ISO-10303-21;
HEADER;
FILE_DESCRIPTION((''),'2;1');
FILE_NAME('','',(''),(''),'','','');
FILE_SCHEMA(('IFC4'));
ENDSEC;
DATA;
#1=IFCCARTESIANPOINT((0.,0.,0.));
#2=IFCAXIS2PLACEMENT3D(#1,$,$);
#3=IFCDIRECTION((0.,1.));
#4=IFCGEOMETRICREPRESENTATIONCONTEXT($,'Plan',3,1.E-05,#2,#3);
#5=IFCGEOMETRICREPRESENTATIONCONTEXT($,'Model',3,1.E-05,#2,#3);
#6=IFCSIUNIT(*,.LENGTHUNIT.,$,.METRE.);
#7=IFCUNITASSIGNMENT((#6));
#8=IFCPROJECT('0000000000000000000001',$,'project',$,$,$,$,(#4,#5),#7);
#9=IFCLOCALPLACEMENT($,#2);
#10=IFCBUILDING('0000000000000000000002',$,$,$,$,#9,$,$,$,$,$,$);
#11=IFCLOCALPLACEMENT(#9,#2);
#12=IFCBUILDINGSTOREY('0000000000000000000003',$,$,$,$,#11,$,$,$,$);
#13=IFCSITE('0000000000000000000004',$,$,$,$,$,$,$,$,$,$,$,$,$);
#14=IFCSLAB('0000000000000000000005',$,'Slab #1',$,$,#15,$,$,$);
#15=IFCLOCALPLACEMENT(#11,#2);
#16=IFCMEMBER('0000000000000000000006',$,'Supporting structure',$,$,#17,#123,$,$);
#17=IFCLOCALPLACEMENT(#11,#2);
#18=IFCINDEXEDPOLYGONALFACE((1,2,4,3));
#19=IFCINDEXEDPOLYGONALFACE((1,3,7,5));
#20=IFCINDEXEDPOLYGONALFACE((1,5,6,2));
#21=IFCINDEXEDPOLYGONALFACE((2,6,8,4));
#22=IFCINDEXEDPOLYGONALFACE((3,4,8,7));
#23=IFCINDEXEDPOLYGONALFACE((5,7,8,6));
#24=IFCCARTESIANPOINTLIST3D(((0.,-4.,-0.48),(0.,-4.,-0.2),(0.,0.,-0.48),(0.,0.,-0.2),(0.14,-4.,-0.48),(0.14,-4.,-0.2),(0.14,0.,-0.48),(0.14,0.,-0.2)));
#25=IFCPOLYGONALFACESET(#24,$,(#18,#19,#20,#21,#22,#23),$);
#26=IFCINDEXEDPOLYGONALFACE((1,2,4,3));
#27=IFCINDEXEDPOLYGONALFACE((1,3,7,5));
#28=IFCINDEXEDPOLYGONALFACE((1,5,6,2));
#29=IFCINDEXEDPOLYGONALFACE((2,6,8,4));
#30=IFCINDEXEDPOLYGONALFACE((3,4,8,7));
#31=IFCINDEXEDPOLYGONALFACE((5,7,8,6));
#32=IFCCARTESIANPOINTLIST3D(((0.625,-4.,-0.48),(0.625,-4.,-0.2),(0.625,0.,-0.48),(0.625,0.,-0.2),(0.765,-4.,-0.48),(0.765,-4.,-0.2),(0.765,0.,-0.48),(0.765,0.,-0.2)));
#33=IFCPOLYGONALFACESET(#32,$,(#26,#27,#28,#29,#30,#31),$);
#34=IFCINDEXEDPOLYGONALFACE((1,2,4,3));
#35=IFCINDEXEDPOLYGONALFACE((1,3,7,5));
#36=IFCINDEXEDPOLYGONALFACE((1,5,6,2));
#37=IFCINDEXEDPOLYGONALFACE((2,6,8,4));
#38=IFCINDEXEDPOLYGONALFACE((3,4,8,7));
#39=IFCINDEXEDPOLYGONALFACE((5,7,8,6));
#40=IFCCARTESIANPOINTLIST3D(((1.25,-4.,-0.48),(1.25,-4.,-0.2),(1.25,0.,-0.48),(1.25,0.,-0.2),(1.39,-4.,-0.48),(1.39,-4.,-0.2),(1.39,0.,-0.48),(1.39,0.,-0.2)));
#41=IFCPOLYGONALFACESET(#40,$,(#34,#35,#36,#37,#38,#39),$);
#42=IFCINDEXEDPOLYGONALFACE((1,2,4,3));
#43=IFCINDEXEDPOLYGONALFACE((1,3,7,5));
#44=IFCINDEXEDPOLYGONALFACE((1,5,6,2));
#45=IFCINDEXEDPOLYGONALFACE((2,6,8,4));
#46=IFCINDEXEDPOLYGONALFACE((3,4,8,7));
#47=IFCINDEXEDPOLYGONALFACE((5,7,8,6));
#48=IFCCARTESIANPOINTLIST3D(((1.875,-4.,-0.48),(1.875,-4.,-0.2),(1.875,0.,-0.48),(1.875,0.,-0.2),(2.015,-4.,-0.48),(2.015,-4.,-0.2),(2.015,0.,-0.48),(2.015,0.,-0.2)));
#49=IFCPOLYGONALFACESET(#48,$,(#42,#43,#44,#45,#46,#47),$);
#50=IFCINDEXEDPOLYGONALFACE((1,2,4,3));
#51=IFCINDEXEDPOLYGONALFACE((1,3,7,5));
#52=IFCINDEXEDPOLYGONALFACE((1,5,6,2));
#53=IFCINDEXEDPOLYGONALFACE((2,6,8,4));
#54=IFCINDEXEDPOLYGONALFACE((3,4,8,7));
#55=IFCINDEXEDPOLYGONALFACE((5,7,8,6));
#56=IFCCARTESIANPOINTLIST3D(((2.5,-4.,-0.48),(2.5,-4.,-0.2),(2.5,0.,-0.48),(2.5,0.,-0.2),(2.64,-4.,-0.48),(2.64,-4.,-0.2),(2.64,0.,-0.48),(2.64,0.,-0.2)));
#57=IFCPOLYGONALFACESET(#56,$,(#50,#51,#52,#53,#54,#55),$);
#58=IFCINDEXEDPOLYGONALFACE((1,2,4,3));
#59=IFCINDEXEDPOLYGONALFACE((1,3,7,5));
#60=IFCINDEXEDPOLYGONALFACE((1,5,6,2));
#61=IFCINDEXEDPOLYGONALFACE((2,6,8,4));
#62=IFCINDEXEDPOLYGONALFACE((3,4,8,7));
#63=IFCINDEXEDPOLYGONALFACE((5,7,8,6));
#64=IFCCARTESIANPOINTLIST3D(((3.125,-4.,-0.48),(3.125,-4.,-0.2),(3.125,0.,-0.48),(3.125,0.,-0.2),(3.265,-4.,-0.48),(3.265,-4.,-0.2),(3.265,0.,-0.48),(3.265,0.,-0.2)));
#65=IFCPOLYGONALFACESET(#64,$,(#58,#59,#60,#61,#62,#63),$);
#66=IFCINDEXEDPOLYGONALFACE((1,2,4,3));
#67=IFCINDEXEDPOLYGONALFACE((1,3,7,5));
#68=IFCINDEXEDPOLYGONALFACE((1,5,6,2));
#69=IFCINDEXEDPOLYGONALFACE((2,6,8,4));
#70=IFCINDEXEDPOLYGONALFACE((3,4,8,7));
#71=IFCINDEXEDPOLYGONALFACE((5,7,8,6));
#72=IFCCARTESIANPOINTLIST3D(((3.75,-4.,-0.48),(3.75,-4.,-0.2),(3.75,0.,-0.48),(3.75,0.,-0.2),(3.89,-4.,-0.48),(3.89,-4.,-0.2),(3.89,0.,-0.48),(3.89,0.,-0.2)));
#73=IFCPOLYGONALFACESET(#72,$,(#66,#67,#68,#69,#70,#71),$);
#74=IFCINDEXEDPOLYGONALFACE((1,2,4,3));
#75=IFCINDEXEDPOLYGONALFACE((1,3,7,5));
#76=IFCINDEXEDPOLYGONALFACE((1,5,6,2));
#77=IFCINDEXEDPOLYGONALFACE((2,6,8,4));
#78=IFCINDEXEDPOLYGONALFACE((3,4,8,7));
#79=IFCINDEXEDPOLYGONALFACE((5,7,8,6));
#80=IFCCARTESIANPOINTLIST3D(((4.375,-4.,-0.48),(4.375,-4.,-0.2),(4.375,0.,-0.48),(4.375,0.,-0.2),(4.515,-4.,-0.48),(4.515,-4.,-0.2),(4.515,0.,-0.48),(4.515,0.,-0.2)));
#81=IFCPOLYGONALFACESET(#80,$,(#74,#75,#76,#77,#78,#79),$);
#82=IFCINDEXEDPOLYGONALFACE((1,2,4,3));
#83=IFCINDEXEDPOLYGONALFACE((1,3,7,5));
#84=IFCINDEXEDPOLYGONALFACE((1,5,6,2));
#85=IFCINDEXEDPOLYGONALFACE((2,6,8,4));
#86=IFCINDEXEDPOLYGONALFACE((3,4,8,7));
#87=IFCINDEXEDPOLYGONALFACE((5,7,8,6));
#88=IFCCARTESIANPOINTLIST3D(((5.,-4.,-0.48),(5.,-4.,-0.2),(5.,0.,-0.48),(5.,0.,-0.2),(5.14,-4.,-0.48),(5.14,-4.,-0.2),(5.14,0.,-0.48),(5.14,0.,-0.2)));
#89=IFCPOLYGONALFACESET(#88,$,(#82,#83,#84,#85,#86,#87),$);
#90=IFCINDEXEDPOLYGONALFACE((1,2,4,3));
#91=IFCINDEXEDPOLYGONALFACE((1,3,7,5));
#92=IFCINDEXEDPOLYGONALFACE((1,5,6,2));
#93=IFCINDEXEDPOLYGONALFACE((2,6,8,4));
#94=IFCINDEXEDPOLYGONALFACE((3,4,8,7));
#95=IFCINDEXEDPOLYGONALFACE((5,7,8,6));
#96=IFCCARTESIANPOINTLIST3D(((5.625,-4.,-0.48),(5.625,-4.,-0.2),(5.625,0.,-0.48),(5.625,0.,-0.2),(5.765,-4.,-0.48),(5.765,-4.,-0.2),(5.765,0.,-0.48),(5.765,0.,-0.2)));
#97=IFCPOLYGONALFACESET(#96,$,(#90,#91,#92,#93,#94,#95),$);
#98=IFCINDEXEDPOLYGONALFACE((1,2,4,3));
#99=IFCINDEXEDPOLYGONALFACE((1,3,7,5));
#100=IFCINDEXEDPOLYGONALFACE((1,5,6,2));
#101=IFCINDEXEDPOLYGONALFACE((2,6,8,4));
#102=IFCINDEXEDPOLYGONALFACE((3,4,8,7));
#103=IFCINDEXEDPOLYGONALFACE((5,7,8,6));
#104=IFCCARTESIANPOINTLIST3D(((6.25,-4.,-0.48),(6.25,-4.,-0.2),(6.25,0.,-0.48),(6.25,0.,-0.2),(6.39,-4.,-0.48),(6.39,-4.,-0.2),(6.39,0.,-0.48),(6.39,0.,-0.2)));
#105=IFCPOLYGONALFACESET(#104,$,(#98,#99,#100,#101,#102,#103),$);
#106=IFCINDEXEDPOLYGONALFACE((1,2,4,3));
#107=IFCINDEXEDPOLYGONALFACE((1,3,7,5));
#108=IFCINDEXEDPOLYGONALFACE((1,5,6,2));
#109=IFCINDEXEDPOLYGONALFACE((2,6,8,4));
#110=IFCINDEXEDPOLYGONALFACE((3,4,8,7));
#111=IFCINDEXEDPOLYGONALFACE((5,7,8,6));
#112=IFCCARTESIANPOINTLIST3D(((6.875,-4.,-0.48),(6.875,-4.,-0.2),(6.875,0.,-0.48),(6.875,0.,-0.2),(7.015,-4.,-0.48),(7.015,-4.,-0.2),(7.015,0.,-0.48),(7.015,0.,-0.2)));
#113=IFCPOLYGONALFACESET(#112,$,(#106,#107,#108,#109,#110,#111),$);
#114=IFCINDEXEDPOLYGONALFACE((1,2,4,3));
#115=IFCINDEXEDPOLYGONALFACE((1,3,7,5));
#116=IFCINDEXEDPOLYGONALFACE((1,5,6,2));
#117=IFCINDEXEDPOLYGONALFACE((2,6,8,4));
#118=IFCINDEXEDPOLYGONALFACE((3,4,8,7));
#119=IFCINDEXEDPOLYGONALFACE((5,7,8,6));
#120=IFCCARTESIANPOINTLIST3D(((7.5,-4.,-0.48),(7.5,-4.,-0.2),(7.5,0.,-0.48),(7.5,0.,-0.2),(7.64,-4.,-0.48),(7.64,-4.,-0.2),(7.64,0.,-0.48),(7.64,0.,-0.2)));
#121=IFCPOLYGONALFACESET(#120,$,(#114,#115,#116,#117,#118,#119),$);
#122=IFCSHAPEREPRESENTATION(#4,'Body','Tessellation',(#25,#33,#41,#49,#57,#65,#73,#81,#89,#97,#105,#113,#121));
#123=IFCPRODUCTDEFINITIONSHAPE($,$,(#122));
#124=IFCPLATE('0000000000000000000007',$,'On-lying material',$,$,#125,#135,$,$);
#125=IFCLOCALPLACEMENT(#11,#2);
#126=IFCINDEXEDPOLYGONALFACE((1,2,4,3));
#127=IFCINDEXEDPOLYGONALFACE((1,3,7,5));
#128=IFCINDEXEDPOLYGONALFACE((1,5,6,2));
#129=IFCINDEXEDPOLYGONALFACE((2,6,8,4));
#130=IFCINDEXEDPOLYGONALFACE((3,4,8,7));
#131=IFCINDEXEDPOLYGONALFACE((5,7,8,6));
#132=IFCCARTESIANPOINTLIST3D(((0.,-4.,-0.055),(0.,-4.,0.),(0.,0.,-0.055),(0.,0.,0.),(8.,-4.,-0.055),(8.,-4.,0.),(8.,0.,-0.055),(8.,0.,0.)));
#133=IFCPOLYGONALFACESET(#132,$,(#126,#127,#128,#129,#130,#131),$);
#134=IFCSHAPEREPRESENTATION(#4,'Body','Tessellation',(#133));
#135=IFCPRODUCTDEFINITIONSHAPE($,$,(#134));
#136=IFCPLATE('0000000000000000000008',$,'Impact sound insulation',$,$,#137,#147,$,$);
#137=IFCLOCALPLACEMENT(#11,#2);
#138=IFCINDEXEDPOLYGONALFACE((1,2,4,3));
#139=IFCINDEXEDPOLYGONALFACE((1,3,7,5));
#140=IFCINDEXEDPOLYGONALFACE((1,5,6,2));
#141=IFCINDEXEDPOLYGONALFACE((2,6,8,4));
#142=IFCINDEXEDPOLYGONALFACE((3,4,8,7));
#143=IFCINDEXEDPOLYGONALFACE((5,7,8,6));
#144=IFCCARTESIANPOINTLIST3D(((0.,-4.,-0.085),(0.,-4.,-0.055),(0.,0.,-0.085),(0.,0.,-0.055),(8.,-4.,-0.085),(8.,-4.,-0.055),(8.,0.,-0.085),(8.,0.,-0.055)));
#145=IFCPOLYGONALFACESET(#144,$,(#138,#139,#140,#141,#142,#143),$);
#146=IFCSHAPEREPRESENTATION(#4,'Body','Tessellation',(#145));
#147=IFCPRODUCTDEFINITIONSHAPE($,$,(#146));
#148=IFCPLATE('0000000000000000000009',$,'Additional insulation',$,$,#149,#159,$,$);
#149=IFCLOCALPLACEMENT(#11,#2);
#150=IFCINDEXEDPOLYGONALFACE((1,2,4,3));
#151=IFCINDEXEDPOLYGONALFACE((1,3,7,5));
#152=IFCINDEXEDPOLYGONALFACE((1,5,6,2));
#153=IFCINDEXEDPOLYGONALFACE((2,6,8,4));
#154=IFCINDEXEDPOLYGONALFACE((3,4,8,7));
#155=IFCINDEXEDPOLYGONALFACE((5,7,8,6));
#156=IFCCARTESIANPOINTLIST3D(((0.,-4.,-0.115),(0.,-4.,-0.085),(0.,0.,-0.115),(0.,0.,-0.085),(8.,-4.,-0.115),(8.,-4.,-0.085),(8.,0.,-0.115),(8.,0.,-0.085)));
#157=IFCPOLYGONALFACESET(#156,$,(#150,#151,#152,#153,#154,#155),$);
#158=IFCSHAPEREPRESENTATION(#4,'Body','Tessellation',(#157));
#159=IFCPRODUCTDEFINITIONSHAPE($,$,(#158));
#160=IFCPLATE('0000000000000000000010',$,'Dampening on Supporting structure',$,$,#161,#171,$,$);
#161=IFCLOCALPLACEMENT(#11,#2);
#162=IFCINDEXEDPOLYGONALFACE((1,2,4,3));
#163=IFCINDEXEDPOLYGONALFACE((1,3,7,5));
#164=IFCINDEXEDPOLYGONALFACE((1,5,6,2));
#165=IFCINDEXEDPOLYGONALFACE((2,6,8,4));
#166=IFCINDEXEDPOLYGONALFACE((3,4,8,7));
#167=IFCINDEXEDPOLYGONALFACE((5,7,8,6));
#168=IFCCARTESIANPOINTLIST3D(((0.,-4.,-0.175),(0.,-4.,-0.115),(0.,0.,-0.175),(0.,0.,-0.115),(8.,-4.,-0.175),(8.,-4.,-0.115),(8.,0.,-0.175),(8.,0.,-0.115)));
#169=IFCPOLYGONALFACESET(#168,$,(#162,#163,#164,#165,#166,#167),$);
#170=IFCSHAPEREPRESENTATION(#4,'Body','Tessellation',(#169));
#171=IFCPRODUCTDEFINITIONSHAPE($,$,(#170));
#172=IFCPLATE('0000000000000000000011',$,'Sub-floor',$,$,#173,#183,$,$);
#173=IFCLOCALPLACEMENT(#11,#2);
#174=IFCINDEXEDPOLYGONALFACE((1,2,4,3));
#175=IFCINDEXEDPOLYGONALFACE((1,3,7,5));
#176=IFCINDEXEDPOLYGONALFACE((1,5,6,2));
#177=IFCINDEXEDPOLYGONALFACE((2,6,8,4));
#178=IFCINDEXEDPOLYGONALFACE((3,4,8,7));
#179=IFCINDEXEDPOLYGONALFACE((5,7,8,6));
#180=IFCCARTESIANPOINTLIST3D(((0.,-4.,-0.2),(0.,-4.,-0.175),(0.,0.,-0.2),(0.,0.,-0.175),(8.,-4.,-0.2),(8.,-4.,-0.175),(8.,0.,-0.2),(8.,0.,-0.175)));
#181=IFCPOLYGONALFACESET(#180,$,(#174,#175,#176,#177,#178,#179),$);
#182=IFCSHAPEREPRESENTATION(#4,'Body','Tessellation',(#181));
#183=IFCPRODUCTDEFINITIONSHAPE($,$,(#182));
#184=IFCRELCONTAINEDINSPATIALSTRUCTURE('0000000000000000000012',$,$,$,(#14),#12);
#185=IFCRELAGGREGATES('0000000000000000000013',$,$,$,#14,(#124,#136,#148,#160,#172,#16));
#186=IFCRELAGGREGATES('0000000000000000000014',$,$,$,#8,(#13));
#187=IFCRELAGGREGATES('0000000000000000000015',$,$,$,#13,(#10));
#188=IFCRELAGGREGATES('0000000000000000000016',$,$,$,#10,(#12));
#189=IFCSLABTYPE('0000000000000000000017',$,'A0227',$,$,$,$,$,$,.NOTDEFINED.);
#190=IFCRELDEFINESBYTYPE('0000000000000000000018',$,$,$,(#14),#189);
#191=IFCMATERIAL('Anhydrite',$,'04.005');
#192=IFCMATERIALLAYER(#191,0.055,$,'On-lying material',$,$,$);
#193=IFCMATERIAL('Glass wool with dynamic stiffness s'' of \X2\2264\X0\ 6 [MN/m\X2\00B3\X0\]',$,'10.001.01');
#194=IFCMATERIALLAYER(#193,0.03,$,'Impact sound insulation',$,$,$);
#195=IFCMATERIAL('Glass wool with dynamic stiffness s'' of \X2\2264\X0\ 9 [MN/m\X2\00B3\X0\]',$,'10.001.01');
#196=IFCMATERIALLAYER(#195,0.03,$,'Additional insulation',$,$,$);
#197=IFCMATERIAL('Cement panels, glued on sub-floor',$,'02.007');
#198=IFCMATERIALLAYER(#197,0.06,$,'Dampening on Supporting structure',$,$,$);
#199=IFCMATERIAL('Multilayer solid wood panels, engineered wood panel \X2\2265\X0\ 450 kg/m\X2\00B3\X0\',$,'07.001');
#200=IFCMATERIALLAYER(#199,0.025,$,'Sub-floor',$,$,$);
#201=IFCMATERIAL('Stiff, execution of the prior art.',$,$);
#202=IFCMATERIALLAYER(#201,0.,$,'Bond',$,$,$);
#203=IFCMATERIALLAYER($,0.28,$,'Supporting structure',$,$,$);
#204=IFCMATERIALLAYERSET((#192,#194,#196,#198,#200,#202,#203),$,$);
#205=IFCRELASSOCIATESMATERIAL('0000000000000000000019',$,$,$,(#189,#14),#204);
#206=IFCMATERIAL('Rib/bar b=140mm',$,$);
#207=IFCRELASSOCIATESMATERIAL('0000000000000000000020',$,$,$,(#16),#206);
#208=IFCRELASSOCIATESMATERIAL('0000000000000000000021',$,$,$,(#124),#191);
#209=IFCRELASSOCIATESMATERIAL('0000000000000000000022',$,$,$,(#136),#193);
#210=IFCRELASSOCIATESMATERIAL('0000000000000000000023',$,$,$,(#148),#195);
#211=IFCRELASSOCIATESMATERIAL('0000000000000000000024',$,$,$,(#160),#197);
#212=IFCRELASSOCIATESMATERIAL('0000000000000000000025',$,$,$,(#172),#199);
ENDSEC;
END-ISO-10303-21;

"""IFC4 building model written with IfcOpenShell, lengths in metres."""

from ifc_helpers import new_model, si_unit, direction, frame, frame_2d, origin, origin_with_axes, place, context, project, spatial, rectangle, extrude, material, layer, layer_set, type_object, element, aggregate, save


model = new_model("IFC4")

# Units and contexts
plan_context = context("Plan", 3, precision=1e-05, world=origin(), true_north=direction((0.0, 1.0)))
model_context = context("Model", 3, precision=1e-05, world=origin(), true_north=direction((0.0, 1.0)))
ifc_project = project(units=[si_unit("LENGTHUNIT", "METRE")], contexts=[plan_context, model_context])

# Site, building, storey
site = spatial("IfcSite", under=ifc_project)
building_placement = place(None, origin())
building = spatial("IfcBuilding", under=site, at=building_placement)
storey_placement = place(building_placement, origin())
storey = spatial("IfcBuildingStorey", under=building, at=storey_placement)

# Slab, member, plates
ifc_material_1 = material(Name="Anhydrite", Category="04.005")
ifc_layer_1 = layer(ifc_material_1, 0.055, Name="On-lying material")
ifc_material_2 = material(Name="Glass wool with dynamic stiffness s' of ≤ 6 [MN/m³]", Category="10.001.01")
ifc_layer_2 = layer(ifc_material_2, 0.03, Name="Impact sound insulation")
ifc_material_3 = material(Name="Glass wool with dynamic stiffness s' of ≤ 9 [MN/m³]", Category="10.001.01")
ifc_layer_3 = layer(ifc_material_3, 0.03, Name="Additional insulation")
ifc_material_4 = material(Name="Cement panels, glued on sub-floor", Category="02.007")
ifc_layer_4 = layer(ifc_material_4, 0.06, Name="Dampening on Supporting structure")
ifc_material_5 = material(Name="Multilayer solid wood panels, engineered wood panel ≥ 450 kg/m³", Category="07.001")
ifc_layer_5 = layer(ifc_material_5, 0.025, Name="Sub-floor")
ifc_material_6 = material(Name="Stiff, execution of the prior art.")
ifc_layer_6 = layer(ifc_material_6, 0.0, Name="Bond")
ifc_layer_7 = layer(None, 0.28, Name="Supporting structure")
ifc_layer_set = layer_set([ifc_layer_1, ifc_layer_2, ifc_layer_3, ifc_layer_4, ifc_layer_5, ifc_layer_6, ifc_layer_7])
slab_type = type_object("IfcSlabType", Name="A0227", PredefinedType="NOTDEFINED", material=ifc_layer_set)
slab_placement = place(None, frame((0.0, 0.0, 0.0), z_axis=(0.0, 0.0, -1.0), x_axis=(1.0, 0.0, 0.0)))
slab = element("IfcSlab", 1, at=slab_placement, inside=storey, type_object=slab_type, material=ifc_layer_set, Name="Slab #1")
ifc_material_7 = material(Name="Rib/bar b=140mm")
member_placement = place(slab_placement, origin())
member = element("IfcMember", 2, at=member_placement, material=ifc_material_7, Name="Supporting structure", context=plan_context, shape_type="SweptSolid", body=[
    extrude(rectangle(XDim=0.14, YDim=0.28, at=frame_2d((0.07, 0.14), x_axis=(1.0, 0.0))), frame((0.0, 4.0, 0.2), z_axis=(0.0, -1.0, 0.0), x_axis=(1.0, 0.0, 0.0)), (0.0, 0.0, 1.0), 4.0),
    extrude(rectangle(XDim=0.14, YDim=0.28, at=frame_2d((0.07, 0.14), x_axis=(1.0, 0.0))), frame((0.625, 4.0, 0.2), z_axis=(0.0, -1.0, 0.0), x_axis=(1.0, 0.0, 0.0)), (0.0, 0.0, 1.0), 4.0),
    extrude(rectangle(XDim=0.14, YDim=0.28, at=frame_2d((0.07, 0.14), x_axis=(1.0, 0.0))), frame((1.25, 4.0, 0.2), z_axis=(0.0, -1.0, 0.0), x_axis=(1.0, 0.0, 0.0)), (0.0, 0.0, 1.0), 4.0),
    extrude(rectangle(XDim=0.14, YDim=0.28, at=frame_2d((0.07, 0.14), x_axis=(1.0, 0.0))), frame((1.875, 4.0, 0.2), z_axis=(0.0, -1.0, 0.0), x_axis=(1.0, 0.0, 0.0)), (0.0, 0.0, 1.0), 4.0),
    extrude(rectangle(XDim=0.14, YDim=0.28, at=frame_2d((0.07, 0.14), x_axis=(1.0, 0.0))), frame((2.5, 4.0, 0.2), z_axis=(0.0, -1.0, 0.0), x_axis=(1.0, 0.0, 0.0)), (0.0, 0.0, 1.0), 4.0),
    extrude(rectangle(XDim=0.14, YDim=0.28, at=frame_2d((0.07, 0.14), x_axis=(1.0, 0.0))), frame((3.125, 4.0, 0.2), z_axis=(0.0, -1.0, 0.0), x_axis=(1.0, 0.0, 0.0)), (0.0, 0.0, 1.0), 4.0),
    extrude(rectangle(XDim=0.14, YDim=0.28, at=frame_2d((0.07, 0.14), x_axis=(1.0, 0.0))), frame((3.75, 4.0, 0.2), z_axis=(0.0, -1.0, 0.0), x_axis=(1.0, 0.0, 0.0)), (0.0, 0.0, 1.0), 4.0),
    extrude(rectangle(XDim=0.14, YDim=0.28, at=frame_2d((0.07, 0.14), x_axis=(1.0, 0.0))), frame((4.375, 4.0, 0.2), z_axis=(0.0, -1.0, 0.0), x_axis=(1.0, 0.0, 0.0)), (0.0, 0.0, 1.0), 4.0),
    extrude(rectangle(XDim=0.14, YDim=0.28, at=frame_2d((0.07, 0.14), x_axis=(1.0, 0.0))), frame((5.0, 4.0, 0.2), z_axis=(0.0, -1.0, 0.0), x_axis=(1.0, 0.0, 0.0)), (0.0, 0.0, 1.0), 4.0),
    extrude(rectangle(XDim=0.14, YDim=0.28, at=frame_2d((0.07, 0.14), x_axis=(1.0, 0.0))), frame((5.625, 4.0, 0.2), z_axis=(0.0, -1.0, 0.0), x_axis=(1.0, 0.0, 0.0)), (0.0, 0.0, 1.0), 4.0),
    extrude(rectangle(XDim=0.14, YDim=0.28, at=frame_2d((0.07, 0.14), x_axis=(1.0, 0.0))), frame((6.25, 4.0, 0.2), z_axis=(0.0, -1.0, 0.0), x_axis=(1.0, 0.0, 0.0)), (0.0, 0.0, 1.0), 4.0),
    extrude(rectangle(XDim=0.14, YDim=0.28, at=frame_2d((0.07, 0.14), x_axis=(1.0, 0.0))), frame((6.875, 4.0, 0.2), z_axis=(0.0, -1.0, 0.0), x_axis=(1.0, 0.0, 0.0)), (0.0, 0.0, 1.0), 4.0),
    extrude(rectangle(XDim=0.14, YDim=0.28, at=frame_2d((0.07, 0.14), x_axis=(1.0, 0.0))), frame((7.5, 4.0, 0.2), z_axis=(0.0, -1.0, 0.0), x_axis=(1.0, 0.0, 0.0)), (0.0, 0.0, 1.0), 4.0),
])
plate_1_placement = place(slab_placement, origin())
plate_1 = element("IfcPlate", 3, at=plate_1_placement, material=ifc_material_1, Name="On-lying material", context=plan_context, shape_type="SweptSolid", body=[
    extrude(rectangle(XDim=8.0, YDim=4.0, at=frame_2d((4.0, 2.0), x_axis=(1.0, 0.0))), origin_with_axes(), (0.0, 0.0, 1.0), 0.055),
])
plate_2_placement = place(slab_placement, origin())
plate_2 = element("IfcPlate", 4, at=plate_2_placement, material=ifc_material_2, Name="Impact sound insulation", context=plan_context, shape_type="SweptSolid", body=[
    extrude(rectangle(XDim=8.0, YDim=4.0, at=frame_2d((4.0, 2.0), x_axis=(1.0, 0.0))), frame((0.0, 0.0, 0.055), z_axis=(0.0, 0.0, 1.0), x_axis=(1.0, 0.0, 0.0)), (0.0, 0.0, 1.0), 0.03),
])
plate_3_placement = place(slab_placement, origin())
plate_3 = element("IfcPlate", 5, at=plate_3_placement, material=ifc_material_3, Name="Additional insulation", context=plan_context, shape_type="SweptSolid", body=[
    extrude(rectangle(XDim=8.0, YDim=4.0, at=frame_2d((4.0, 2.0), x_axis=(1.0, 0.0))), frame((0.0, 0.0, 0.085), z_axis=(0.0, 0.0, 1.0), x_axis=(1.0, 0.0, 0.0)), (0.0, 0.0, 1.0), 0.03),
])
plate_4_placement = place(slab_placement, origin())
plate_4 = element("IfcPlate", 6, at=plate_4_placement, material=ifc_material_4, Name="Dampening on Supporting structure", context=plan_context, shape_type="SweptSolid", body=[
    extrude(rectangle(XDim=8.0, YDim=4.0, at=frame_2d((4.0, 2.0), x_axis=(1.0, 0.0))), frame((0.0, 0.0, 0.115), z_axis=(0.0, 0.0, 1.0), x_axis=(1.0, 0.0, 0.0)), (0.0, 0.0, 1.0), 0.06),
])
plate_5_placement = place(slab_placement, origin())
plate_5 = element("IfcPlate", 7, at=plate_5_placement, material=ifc_material_5, Name="Sub-floor", context=plan_context, shape_type="SweptSolid", body=[
    extrude(rectangle(XDim=8.0, YDim=4.0, at=frame_2d((4.0, 2.0), x_axis=(1.0, 0.0))), frame((0.0, 0.0, 0.175), z_axis=(0.0, 0.0, 1.0), x_axis=(1.0, 0.0, 0.0)), (0.0, 0.0, 1.0), 0.025),
])
aggregate(slab, [plate_1, plate_2, plate_3, plate_4, plate_5, member])

save(model, "model.ifc")
